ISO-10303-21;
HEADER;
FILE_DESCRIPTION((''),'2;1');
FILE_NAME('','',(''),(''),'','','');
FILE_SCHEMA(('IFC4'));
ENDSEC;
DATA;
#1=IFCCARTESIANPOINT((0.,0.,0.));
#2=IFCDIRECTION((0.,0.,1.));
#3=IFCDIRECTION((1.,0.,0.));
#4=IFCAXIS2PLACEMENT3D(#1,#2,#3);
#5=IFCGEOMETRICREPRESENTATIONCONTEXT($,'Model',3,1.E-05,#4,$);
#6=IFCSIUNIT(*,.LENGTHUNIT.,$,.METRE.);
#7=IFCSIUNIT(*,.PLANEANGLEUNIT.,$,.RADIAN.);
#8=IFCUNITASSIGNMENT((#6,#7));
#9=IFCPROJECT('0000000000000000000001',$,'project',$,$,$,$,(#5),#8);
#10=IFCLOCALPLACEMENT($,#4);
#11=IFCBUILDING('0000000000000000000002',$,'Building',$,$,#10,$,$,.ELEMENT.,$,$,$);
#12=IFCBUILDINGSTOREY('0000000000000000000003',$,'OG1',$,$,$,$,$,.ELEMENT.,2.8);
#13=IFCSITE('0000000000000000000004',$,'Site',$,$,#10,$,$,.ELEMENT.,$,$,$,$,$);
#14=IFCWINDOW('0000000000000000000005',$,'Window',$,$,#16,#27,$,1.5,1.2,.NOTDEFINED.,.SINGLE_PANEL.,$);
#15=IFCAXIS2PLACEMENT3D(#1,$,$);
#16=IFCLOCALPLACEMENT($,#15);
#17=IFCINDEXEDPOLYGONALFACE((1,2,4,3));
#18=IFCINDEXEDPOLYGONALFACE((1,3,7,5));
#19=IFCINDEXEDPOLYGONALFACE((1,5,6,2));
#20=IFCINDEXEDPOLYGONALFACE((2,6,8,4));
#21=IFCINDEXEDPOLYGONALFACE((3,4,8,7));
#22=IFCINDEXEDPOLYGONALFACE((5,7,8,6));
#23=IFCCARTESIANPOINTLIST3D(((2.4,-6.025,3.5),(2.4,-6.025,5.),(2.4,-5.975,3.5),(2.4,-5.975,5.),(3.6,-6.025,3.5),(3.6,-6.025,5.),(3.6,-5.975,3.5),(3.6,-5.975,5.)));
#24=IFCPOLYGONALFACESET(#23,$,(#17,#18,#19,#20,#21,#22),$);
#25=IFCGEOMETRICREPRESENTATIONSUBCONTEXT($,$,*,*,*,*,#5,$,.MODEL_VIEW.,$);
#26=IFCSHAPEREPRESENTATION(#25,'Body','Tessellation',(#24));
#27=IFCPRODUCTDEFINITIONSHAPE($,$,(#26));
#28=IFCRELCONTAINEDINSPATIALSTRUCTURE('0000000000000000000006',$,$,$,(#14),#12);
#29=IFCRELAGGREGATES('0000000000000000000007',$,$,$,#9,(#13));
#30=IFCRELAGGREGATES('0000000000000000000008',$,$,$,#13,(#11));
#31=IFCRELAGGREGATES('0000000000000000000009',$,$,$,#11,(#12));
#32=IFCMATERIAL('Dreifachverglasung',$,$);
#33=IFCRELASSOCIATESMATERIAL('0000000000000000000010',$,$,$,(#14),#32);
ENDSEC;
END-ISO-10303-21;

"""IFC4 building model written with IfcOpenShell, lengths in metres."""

from ifc_helpers import new_model, si_unit, frame, origin, origin_with_axes, origin_2d, place, context, subcontext, project, spatial, rectangle, extrude, material, element, save


model = new_model("IFC4")

# Units and contexts
model_context = context("Model", 3, precision=1e-05, world=origin_with_axes())
sub_context = subcontext(model_context, None, None, "MODEL_VIEW")
ifc_project = project(units=[si_unit("LENGTHUNIT", "METRE"), si_unit("PLANEANGLEUNIT", "RADIAN")], contexts=[model_context])

# Site, building, storey
placement_1 = place(None, origin_with_axes())
site = spatial("IfcSite", under=ifc_project, at=placement_1, Name="Site", CompositionType="ELEMENT")
building = spatial("IfcBuilding", under=site, at=placement_1, Name="Building", CompositionType="ELEMENT")
storey = spatial("IfcBuildingStorey", under=building, Name="OG1", CompositionType="ELEMENT", Elevation=2.8)

# Window
ifc_material = material(Name="Dreifachverglasung")
placement_2 = place(None, origin_with_axes())
window_placement = place(placement_2, frame((3.0, -6.0, 3.5)))
element("IfcWindow", 1, at=window_placement, inside=storey, material=ifc_material, Name="Window", OverallHeight=1.5, OverallWidth=1.2, PartitioningType="SINGLE_PANEL", PredefinedType="NOTDEFINED", context=sub_context, shape_type="SweptSolid", body=[
    extrude(rectangle(XDim=1.2, YDim=0.05, at=origin_2d()), origin(), (0.0, 0.0, 1.0), 1.5),
])

save(model, "model.ifc")
